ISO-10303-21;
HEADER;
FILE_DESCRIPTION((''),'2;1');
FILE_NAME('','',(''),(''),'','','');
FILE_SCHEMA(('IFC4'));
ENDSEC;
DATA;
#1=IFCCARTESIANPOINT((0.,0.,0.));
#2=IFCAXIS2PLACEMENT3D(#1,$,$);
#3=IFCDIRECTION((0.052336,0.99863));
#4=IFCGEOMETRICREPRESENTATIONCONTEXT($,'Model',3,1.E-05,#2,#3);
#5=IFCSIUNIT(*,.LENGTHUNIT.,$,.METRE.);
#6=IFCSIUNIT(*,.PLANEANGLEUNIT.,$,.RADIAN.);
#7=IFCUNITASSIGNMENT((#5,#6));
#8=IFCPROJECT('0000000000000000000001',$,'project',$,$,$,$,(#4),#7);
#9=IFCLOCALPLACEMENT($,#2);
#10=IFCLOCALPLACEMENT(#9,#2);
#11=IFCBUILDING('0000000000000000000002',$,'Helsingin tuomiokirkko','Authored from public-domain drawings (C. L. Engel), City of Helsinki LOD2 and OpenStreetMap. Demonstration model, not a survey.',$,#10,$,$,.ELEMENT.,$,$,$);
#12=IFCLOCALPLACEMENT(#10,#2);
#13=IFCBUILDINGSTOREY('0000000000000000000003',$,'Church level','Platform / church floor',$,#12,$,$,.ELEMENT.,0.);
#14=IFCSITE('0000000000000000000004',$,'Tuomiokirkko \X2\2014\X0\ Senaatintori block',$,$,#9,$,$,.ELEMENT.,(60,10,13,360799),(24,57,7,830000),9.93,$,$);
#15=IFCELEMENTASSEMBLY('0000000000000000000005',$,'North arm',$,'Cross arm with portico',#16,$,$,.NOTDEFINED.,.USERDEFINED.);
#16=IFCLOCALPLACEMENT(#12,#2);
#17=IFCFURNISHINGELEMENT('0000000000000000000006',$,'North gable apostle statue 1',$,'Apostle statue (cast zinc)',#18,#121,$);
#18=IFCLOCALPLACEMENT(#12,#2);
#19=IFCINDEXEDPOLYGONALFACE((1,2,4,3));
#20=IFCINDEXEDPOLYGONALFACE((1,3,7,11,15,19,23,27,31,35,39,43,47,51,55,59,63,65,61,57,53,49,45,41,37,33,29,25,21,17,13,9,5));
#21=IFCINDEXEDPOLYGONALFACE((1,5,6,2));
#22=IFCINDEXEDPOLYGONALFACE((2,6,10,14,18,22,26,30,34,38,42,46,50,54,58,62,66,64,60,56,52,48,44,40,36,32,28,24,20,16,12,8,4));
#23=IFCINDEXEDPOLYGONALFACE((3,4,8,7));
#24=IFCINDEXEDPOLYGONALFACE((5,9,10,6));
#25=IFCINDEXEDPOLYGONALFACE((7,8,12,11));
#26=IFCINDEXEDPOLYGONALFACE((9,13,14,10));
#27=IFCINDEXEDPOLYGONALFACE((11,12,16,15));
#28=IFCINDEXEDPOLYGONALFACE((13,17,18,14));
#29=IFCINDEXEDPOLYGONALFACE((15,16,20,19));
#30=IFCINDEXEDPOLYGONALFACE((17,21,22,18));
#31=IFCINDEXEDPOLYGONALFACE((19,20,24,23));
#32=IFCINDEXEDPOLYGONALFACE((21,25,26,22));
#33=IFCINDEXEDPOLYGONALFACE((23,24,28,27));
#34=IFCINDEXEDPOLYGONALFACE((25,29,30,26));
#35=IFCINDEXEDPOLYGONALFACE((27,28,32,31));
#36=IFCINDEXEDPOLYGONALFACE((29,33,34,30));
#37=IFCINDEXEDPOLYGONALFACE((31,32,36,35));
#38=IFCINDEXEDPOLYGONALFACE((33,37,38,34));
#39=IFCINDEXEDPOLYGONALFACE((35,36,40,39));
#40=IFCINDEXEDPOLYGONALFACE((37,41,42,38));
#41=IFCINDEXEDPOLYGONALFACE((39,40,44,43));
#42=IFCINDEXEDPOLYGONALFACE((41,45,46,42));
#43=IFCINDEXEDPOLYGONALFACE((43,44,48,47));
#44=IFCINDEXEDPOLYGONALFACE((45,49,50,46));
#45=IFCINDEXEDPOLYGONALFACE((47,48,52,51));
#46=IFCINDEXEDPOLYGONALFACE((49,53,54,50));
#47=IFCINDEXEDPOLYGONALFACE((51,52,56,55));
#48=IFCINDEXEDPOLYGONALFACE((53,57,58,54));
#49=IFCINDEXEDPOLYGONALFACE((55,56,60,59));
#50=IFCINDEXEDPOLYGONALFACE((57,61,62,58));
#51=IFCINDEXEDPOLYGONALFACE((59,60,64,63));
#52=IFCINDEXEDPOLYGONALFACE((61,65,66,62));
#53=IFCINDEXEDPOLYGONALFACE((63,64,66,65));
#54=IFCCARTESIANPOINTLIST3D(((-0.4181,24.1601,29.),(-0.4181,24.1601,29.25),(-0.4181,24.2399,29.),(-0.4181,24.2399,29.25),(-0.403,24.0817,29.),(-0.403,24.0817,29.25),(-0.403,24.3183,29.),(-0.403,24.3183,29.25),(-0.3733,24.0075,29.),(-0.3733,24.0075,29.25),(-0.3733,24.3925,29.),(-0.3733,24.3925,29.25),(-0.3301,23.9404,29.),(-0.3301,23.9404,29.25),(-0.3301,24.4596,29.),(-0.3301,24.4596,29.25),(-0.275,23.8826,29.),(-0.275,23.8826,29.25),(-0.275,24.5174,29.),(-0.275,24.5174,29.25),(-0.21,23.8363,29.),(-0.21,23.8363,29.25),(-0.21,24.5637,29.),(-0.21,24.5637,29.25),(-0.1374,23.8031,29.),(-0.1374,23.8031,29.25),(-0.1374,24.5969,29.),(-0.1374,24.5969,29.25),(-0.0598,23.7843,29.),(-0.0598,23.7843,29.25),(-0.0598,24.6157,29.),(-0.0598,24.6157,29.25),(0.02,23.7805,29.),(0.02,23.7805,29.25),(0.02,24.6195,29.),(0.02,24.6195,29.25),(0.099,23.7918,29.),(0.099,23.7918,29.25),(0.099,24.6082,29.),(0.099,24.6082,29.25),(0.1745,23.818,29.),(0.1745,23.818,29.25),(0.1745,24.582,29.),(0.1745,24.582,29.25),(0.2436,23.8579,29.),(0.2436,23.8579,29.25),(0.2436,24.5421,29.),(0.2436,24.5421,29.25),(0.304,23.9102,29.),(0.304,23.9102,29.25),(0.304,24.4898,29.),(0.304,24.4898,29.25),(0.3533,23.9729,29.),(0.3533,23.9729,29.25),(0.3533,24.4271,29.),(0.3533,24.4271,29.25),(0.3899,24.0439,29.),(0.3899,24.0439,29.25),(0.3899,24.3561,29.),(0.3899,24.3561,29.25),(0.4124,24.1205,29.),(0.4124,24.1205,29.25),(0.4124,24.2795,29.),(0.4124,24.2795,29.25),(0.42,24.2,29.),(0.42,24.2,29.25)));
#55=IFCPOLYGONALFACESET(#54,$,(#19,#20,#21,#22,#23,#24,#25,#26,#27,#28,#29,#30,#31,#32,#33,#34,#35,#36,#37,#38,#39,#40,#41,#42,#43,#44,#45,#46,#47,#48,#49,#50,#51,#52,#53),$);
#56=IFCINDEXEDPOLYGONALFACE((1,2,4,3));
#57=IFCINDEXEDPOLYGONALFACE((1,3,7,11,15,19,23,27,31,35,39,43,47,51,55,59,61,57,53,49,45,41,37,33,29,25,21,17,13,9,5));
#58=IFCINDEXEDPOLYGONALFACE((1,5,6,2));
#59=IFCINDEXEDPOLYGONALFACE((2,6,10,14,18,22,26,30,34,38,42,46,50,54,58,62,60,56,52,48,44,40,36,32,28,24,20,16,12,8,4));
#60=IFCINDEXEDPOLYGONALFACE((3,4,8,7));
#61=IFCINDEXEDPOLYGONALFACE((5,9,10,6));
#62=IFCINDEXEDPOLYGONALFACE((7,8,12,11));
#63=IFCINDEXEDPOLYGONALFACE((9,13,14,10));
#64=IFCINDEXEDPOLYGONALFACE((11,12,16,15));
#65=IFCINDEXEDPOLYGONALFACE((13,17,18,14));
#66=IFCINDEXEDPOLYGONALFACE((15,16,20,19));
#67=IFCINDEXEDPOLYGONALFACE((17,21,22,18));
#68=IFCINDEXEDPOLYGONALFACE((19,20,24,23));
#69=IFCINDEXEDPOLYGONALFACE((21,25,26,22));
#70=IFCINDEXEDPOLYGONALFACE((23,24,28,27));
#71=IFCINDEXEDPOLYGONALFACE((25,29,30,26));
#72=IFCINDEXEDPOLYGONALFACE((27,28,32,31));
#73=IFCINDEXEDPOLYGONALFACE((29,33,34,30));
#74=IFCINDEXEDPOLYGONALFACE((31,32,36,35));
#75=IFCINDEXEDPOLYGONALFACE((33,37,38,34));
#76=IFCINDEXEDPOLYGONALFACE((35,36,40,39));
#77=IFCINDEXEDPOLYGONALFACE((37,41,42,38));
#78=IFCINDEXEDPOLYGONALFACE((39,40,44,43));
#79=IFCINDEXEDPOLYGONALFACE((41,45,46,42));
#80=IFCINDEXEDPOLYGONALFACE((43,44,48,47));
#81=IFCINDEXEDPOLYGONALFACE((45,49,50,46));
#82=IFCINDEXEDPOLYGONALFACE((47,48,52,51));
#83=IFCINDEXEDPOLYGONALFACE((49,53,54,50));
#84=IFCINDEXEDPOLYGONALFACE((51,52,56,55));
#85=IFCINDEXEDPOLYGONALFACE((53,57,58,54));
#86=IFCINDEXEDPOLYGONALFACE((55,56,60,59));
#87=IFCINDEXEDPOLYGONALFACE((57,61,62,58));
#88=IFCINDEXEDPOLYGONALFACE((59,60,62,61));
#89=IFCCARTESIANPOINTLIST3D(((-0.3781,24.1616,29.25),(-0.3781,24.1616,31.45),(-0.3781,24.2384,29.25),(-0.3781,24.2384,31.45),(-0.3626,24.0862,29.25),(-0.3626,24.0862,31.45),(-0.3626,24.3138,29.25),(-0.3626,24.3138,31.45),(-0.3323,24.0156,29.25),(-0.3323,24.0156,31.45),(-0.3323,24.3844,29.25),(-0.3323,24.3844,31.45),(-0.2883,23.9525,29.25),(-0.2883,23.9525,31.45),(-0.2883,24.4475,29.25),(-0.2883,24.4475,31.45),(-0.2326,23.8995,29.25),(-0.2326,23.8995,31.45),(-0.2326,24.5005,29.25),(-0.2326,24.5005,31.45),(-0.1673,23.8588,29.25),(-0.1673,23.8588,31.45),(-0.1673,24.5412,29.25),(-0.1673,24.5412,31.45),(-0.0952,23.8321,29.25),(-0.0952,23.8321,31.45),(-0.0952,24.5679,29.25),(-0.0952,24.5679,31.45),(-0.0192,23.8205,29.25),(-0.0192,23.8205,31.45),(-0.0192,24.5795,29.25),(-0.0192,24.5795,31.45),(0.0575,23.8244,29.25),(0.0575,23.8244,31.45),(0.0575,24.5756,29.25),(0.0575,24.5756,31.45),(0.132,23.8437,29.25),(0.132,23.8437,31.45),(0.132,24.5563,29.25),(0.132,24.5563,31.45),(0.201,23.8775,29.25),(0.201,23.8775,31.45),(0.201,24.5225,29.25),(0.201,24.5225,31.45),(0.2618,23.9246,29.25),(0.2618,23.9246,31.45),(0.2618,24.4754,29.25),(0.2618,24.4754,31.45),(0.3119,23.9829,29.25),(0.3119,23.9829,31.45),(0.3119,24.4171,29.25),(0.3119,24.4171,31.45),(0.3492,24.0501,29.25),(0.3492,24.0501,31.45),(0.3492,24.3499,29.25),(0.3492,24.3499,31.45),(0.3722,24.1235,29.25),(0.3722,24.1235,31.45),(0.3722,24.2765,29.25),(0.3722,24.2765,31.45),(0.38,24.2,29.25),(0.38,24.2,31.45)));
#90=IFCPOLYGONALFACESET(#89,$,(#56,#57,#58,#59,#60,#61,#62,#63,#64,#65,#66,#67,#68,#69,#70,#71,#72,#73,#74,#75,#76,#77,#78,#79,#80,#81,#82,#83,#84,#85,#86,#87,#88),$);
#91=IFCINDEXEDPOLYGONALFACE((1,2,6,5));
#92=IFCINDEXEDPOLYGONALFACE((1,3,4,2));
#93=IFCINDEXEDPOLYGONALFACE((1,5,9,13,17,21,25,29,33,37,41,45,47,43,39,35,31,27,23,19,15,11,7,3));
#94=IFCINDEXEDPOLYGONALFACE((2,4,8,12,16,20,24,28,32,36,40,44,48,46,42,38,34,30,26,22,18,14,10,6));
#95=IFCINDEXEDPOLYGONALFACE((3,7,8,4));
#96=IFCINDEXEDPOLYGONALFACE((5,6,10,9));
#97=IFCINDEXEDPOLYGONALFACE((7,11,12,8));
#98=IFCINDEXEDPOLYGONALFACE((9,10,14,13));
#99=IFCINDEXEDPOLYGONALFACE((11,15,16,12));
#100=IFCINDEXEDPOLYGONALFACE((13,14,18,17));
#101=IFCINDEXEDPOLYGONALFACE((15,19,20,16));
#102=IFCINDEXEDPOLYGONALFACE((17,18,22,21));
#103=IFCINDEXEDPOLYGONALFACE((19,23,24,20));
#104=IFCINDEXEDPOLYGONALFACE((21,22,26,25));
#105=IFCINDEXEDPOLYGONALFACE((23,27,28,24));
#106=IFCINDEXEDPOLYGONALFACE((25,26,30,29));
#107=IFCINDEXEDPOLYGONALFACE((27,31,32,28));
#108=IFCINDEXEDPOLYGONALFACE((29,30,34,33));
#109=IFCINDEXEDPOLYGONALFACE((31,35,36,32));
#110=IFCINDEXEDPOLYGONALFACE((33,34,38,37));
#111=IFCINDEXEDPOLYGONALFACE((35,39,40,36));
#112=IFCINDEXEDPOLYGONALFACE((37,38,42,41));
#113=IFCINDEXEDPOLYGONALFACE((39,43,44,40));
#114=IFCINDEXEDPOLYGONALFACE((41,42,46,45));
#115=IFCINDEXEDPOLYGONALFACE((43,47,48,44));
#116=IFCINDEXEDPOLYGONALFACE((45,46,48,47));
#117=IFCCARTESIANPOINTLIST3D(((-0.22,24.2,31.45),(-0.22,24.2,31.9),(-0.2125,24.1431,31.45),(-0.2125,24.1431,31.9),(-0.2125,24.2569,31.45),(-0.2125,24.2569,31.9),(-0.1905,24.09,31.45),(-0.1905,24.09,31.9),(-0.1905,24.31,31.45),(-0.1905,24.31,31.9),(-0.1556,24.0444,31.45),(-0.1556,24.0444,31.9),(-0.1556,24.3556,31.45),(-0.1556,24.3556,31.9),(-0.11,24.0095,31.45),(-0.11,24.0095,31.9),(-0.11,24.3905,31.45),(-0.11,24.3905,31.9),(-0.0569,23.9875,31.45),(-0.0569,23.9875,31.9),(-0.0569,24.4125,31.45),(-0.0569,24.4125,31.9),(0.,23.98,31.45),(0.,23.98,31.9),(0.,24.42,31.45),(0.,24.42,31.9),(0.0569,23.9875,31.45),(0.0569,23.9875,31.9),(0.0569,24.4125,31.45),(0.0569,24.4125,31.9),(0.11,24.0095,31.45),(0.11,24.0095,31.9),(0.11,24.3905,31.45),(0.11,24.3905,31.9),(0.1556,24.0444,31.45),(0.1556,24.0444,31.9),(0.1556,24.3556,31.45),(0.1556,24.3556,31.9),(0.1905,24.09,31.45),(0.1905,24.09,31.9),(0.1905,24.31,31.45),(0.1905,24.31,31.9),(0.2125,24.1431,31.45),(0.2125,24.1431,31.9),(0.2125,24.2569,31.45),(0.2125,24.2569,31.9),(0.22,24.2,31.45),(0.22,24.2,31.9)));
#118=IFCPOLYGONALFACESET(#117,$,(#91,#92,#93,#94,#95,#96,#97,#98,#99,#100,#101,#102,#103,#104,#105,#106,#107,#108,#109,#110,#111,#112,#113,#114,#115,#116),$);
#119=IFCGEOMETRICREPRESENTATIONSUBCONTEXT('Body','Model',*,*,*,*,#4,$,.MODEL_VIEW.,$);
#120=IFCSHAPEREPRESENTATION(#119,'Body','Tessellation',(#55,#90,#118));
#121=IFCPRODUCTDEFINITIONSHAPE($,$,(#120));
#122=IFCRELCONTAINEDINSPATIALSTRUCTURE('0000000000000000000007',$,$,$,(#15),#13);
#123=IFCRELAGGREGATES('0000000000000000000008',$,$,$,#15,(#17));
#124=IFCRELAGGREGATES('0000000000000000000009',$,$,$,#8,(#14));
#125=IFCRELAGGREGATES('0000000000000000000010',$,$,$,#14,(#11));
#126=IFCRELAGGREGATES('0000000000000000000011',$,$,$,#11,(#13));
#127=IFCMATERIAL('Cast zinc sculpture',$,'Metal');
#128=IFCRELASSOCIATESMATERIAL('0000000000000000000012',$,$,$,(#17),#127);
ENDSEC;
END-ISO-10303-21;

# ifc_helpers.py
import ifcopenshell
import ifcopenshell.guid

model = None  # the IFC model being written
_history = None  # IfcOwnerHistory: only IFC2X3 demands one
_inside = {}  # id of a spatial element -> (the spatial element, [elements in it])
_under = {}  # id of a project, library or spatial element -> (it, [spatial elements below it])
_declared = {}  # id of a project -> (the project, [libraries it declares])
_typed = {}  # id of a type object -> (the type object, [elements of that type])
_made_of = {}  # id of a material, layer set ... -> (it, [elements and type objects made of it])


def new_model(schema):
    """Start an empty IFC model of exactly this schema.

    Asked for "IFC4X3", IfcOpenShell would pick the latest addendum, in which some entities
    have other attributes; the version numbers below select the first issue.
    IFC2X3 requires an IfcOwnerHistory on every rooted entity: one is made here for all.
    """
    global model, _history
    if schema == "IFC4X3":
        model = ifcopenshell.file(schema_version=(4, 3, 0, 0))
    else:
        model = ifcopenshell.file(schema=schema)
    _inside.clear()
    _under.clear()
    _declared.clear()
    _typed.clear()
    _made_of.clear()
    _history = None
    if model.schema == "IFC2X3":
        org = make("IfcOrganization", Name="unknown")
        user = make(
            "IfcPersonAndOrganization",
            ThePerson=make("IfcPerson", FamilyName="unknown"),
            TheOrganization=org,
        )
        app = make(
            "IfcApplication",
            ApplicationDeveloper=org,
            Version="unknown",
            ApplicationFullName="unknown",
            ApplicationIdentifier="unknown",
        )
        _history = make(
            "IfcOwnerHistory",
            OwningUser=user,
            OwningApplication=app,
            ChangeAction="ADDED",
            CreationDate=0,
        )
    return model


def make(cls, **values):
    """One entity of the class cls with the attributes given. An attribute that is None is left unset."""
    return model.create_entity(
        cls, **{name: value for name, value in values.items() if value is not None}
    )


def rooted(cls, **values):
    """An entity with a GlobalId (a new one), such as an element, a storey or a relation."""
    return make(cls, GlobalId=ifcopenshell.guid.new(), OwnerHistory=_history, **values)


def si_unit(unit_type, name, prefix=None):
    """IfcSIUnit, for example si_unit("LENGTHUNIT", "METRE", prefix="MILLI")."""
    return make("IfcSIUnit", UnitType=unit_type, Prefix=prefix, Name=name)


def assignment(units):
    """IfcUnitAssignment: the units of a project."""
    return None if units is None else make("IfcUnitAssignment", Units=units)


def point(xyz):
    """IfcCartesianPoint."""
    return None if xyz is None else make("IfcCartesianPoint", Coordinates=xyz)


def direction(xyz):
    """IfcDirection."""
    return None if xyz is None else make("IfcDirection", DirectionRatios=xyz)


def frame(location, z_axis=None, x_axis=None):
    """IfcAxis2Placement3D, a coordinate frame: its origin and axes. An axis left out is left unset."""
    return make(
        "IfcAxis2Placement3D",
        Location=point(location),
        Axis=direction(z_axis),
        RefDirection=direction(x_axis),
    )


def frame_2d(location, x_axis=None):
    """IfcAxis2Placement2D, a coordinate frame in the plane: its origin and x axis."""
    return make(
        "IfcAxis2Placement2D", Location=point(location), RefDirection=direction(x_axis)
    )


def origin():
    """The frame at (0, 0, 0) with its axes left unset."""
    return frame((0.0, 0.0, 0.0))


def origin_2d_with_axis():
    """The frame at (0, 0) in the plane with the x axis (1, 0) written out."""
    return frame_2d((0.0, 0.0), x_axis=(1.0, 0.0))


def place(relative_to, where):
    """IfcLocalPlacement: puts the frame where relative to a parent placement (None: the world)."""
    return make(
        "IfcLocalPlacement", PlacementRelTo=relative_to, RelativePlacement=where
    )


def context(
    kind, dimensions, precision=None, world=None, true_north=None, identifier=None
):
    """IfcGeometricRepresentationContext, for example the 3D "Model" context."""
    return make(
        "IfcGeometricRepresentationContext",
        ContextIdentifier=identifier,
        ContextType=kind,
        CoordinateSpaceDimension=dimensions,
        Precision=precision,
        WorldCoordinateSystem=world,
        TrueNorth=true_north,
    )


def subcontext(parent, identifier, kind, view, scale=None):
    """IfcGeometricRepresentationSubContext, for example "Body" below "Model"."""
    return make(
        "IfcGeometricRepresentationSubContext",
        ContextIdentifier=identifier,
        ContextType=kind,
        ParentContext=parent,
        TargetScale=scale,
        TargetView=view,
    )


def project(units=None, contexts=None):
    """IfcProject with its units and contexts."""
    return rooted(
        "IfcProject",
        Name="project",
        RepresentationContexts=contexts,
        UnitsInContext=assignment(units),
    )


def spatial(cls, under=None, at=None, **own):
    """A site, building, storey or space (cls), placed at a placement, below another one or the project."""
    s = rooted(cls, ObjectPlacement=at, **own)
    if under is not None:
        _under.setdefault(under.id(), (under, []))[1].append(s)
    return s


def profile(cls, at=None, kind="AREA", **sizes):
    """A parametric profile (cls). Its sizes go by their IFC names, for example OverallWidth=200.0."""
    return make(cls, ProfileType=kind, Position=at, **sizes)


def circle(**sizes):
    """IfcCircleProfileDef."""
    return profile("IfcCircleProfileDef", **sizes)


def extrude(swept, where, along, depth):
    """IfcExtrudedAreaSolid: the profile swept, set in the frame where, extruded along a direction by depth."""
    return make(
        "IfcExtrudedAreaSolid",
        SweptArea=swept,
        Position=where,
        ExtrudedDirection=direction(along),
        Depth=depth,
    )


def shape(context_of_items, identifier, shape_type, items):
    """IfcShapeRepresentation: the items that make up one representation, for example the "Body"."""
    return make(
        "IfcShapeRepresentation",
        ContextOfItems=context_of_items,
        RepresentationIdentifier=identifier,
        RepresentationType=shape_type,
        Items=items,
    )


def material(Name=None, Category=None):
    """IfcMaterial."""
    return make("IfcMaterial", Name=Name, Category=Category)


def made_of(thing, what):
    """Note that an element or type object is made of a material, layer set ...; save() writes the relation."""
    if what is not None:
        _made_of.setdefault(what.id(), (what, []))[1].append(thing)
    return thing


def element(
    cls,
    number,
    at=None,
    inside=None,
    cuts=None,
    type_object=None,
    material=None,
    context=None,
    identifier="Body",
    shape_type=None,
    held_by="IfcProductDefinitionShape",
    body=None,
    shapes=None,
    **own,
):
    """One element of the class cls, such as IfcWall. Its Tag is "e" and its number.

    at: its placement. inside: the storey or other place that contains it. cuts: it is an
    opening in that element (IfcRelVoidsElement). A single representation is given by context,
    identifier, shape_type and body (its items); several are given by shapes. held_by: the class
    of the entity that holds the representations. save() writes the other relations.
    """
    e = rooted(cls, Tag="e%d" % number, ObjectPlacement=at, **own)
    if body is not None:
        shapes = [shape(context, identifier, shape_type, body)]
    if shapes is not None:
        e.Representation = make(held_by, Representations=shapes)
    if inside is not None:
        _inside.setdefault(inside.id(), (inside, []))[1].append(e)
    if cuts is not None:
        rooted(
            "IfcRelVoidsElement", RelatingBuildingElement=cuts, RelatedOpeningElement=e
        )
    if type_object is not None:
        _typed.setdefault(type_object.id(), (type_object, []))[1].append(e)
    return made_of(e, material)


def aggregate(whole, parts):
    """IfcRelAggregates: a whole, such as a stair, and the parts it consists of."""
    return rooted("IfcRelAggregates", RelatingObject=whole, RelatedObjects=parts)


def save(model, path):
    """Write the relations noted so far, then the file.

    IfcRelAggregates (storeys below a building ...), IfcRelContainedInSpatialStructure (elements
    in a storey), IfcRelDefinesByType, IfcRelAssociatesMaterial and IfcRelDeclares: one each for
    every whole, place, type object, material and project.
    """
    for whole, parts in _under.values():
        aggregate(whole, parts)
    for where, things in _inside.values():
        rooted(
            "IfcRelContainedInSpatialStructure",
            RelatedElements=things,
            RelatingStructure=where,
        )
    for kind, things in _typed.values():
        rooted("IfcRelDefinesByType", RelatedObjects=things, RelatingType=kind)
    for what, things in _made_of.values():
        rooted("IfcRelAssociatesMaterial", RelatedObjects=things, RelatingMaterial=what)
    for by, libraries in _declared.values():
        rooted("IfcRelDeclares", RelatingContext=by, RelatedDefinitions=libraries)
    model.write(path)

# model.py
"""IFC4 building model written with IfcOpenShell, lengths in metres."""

from ifc_helpers import new_model, si_unit, direction, frame, origin, origin_2d_with_axis, place, context, subcontext, project, spatial, circle, extrude, material, element, aggregate, save


model = new_model("IFC4")

# Units and contexts
model_context = context("Model", 3, precision=1e-05, world=origin(), true_north=direction((0.052336, 0.99863)))
body_context = subcontext(model_context, "Body", "Model", "MODEL_VIEW")
ifc_project = project(units=[si_unit("LENGTHUNIT", "METRE"), si_unit("PLANEANGLEUNIT", "RADIAN")], contexts=[model_context])

# Site, building, storey
site_placement = place(None, origin())
site = spatial("IfcSite", under=ifc_project, at=site_placement, Name="Tuomiokirkko — Senaatintori block", CompositionType="ELEMENT", RefLatitude=(60, 10, 13, 360799), RefLongitude=(24, 57, 7, 830000), RefElevation=9.93)
building_placement = place(site_placement, origin())
building = spatial("IfcBuilding", under=site, at=building_placement, Name="Helsingin tuomiokirkko", Description="Authored from public-domain drawings (C. L. Engel), City of Helsinki LOD2 and OpenStreetMap. Demonstration model, not a survey.", CompositionType="ELEMENT")
storey_placement = place(building_placement, origin())
storey = spatial("IfcBuildingStorey", under=building, at=storey_placement, Name="Church level", Description="Platform / church floor", CompositionType="ELEMENT", Elevation=0.0)

# Element assembly
assembly_1_placement = place(building_placement, origin())
assembly_1 = element("IfcElementAssembly", 1, at=assembly_1_placement, inside=storey, Name="North arm", ObjectType="Cross arm with portico", AssemblyPlace="NOTDEFINED", PredefinedType="USERDEFINED")

# Furnishing element
ifc_material_1 = material(Name="Cast zinc sculpture", Category="Metal")
furnishing_1_placement = place(building_placement, origin())
furnishing_1 = element("IfcFurnishingElement", 2, at=furnishing_1_placement, material=ifc_material_1, Name="North gable apostle statue 1", ObjectType="Apostle statue (cast zinc)", context=body_context, shape_type="SweptSolid", body=[
    extrude(circle(Radius=0.42, at=origin_2d_with_axis()), frame((0.0, 24.2, 29.0)), (0.0, 0.0, 1.0), 0.25),
    extrude(circle(Radius=0.38, at=origin_2d_with_axis()), frame((0.0, 24.2, 29.25)), (0.0, 0.0, 1.0), 2.2),
    extrude(circle(Radius=0.22, at=origin_2d_with_axis()), frame((0.0, 24.2, 31.45)), (0.0, 0.0, 1.0), 0.45),
])
aggregate(assembly_1, [furnishing_1])

save(model, "model.ifc")
